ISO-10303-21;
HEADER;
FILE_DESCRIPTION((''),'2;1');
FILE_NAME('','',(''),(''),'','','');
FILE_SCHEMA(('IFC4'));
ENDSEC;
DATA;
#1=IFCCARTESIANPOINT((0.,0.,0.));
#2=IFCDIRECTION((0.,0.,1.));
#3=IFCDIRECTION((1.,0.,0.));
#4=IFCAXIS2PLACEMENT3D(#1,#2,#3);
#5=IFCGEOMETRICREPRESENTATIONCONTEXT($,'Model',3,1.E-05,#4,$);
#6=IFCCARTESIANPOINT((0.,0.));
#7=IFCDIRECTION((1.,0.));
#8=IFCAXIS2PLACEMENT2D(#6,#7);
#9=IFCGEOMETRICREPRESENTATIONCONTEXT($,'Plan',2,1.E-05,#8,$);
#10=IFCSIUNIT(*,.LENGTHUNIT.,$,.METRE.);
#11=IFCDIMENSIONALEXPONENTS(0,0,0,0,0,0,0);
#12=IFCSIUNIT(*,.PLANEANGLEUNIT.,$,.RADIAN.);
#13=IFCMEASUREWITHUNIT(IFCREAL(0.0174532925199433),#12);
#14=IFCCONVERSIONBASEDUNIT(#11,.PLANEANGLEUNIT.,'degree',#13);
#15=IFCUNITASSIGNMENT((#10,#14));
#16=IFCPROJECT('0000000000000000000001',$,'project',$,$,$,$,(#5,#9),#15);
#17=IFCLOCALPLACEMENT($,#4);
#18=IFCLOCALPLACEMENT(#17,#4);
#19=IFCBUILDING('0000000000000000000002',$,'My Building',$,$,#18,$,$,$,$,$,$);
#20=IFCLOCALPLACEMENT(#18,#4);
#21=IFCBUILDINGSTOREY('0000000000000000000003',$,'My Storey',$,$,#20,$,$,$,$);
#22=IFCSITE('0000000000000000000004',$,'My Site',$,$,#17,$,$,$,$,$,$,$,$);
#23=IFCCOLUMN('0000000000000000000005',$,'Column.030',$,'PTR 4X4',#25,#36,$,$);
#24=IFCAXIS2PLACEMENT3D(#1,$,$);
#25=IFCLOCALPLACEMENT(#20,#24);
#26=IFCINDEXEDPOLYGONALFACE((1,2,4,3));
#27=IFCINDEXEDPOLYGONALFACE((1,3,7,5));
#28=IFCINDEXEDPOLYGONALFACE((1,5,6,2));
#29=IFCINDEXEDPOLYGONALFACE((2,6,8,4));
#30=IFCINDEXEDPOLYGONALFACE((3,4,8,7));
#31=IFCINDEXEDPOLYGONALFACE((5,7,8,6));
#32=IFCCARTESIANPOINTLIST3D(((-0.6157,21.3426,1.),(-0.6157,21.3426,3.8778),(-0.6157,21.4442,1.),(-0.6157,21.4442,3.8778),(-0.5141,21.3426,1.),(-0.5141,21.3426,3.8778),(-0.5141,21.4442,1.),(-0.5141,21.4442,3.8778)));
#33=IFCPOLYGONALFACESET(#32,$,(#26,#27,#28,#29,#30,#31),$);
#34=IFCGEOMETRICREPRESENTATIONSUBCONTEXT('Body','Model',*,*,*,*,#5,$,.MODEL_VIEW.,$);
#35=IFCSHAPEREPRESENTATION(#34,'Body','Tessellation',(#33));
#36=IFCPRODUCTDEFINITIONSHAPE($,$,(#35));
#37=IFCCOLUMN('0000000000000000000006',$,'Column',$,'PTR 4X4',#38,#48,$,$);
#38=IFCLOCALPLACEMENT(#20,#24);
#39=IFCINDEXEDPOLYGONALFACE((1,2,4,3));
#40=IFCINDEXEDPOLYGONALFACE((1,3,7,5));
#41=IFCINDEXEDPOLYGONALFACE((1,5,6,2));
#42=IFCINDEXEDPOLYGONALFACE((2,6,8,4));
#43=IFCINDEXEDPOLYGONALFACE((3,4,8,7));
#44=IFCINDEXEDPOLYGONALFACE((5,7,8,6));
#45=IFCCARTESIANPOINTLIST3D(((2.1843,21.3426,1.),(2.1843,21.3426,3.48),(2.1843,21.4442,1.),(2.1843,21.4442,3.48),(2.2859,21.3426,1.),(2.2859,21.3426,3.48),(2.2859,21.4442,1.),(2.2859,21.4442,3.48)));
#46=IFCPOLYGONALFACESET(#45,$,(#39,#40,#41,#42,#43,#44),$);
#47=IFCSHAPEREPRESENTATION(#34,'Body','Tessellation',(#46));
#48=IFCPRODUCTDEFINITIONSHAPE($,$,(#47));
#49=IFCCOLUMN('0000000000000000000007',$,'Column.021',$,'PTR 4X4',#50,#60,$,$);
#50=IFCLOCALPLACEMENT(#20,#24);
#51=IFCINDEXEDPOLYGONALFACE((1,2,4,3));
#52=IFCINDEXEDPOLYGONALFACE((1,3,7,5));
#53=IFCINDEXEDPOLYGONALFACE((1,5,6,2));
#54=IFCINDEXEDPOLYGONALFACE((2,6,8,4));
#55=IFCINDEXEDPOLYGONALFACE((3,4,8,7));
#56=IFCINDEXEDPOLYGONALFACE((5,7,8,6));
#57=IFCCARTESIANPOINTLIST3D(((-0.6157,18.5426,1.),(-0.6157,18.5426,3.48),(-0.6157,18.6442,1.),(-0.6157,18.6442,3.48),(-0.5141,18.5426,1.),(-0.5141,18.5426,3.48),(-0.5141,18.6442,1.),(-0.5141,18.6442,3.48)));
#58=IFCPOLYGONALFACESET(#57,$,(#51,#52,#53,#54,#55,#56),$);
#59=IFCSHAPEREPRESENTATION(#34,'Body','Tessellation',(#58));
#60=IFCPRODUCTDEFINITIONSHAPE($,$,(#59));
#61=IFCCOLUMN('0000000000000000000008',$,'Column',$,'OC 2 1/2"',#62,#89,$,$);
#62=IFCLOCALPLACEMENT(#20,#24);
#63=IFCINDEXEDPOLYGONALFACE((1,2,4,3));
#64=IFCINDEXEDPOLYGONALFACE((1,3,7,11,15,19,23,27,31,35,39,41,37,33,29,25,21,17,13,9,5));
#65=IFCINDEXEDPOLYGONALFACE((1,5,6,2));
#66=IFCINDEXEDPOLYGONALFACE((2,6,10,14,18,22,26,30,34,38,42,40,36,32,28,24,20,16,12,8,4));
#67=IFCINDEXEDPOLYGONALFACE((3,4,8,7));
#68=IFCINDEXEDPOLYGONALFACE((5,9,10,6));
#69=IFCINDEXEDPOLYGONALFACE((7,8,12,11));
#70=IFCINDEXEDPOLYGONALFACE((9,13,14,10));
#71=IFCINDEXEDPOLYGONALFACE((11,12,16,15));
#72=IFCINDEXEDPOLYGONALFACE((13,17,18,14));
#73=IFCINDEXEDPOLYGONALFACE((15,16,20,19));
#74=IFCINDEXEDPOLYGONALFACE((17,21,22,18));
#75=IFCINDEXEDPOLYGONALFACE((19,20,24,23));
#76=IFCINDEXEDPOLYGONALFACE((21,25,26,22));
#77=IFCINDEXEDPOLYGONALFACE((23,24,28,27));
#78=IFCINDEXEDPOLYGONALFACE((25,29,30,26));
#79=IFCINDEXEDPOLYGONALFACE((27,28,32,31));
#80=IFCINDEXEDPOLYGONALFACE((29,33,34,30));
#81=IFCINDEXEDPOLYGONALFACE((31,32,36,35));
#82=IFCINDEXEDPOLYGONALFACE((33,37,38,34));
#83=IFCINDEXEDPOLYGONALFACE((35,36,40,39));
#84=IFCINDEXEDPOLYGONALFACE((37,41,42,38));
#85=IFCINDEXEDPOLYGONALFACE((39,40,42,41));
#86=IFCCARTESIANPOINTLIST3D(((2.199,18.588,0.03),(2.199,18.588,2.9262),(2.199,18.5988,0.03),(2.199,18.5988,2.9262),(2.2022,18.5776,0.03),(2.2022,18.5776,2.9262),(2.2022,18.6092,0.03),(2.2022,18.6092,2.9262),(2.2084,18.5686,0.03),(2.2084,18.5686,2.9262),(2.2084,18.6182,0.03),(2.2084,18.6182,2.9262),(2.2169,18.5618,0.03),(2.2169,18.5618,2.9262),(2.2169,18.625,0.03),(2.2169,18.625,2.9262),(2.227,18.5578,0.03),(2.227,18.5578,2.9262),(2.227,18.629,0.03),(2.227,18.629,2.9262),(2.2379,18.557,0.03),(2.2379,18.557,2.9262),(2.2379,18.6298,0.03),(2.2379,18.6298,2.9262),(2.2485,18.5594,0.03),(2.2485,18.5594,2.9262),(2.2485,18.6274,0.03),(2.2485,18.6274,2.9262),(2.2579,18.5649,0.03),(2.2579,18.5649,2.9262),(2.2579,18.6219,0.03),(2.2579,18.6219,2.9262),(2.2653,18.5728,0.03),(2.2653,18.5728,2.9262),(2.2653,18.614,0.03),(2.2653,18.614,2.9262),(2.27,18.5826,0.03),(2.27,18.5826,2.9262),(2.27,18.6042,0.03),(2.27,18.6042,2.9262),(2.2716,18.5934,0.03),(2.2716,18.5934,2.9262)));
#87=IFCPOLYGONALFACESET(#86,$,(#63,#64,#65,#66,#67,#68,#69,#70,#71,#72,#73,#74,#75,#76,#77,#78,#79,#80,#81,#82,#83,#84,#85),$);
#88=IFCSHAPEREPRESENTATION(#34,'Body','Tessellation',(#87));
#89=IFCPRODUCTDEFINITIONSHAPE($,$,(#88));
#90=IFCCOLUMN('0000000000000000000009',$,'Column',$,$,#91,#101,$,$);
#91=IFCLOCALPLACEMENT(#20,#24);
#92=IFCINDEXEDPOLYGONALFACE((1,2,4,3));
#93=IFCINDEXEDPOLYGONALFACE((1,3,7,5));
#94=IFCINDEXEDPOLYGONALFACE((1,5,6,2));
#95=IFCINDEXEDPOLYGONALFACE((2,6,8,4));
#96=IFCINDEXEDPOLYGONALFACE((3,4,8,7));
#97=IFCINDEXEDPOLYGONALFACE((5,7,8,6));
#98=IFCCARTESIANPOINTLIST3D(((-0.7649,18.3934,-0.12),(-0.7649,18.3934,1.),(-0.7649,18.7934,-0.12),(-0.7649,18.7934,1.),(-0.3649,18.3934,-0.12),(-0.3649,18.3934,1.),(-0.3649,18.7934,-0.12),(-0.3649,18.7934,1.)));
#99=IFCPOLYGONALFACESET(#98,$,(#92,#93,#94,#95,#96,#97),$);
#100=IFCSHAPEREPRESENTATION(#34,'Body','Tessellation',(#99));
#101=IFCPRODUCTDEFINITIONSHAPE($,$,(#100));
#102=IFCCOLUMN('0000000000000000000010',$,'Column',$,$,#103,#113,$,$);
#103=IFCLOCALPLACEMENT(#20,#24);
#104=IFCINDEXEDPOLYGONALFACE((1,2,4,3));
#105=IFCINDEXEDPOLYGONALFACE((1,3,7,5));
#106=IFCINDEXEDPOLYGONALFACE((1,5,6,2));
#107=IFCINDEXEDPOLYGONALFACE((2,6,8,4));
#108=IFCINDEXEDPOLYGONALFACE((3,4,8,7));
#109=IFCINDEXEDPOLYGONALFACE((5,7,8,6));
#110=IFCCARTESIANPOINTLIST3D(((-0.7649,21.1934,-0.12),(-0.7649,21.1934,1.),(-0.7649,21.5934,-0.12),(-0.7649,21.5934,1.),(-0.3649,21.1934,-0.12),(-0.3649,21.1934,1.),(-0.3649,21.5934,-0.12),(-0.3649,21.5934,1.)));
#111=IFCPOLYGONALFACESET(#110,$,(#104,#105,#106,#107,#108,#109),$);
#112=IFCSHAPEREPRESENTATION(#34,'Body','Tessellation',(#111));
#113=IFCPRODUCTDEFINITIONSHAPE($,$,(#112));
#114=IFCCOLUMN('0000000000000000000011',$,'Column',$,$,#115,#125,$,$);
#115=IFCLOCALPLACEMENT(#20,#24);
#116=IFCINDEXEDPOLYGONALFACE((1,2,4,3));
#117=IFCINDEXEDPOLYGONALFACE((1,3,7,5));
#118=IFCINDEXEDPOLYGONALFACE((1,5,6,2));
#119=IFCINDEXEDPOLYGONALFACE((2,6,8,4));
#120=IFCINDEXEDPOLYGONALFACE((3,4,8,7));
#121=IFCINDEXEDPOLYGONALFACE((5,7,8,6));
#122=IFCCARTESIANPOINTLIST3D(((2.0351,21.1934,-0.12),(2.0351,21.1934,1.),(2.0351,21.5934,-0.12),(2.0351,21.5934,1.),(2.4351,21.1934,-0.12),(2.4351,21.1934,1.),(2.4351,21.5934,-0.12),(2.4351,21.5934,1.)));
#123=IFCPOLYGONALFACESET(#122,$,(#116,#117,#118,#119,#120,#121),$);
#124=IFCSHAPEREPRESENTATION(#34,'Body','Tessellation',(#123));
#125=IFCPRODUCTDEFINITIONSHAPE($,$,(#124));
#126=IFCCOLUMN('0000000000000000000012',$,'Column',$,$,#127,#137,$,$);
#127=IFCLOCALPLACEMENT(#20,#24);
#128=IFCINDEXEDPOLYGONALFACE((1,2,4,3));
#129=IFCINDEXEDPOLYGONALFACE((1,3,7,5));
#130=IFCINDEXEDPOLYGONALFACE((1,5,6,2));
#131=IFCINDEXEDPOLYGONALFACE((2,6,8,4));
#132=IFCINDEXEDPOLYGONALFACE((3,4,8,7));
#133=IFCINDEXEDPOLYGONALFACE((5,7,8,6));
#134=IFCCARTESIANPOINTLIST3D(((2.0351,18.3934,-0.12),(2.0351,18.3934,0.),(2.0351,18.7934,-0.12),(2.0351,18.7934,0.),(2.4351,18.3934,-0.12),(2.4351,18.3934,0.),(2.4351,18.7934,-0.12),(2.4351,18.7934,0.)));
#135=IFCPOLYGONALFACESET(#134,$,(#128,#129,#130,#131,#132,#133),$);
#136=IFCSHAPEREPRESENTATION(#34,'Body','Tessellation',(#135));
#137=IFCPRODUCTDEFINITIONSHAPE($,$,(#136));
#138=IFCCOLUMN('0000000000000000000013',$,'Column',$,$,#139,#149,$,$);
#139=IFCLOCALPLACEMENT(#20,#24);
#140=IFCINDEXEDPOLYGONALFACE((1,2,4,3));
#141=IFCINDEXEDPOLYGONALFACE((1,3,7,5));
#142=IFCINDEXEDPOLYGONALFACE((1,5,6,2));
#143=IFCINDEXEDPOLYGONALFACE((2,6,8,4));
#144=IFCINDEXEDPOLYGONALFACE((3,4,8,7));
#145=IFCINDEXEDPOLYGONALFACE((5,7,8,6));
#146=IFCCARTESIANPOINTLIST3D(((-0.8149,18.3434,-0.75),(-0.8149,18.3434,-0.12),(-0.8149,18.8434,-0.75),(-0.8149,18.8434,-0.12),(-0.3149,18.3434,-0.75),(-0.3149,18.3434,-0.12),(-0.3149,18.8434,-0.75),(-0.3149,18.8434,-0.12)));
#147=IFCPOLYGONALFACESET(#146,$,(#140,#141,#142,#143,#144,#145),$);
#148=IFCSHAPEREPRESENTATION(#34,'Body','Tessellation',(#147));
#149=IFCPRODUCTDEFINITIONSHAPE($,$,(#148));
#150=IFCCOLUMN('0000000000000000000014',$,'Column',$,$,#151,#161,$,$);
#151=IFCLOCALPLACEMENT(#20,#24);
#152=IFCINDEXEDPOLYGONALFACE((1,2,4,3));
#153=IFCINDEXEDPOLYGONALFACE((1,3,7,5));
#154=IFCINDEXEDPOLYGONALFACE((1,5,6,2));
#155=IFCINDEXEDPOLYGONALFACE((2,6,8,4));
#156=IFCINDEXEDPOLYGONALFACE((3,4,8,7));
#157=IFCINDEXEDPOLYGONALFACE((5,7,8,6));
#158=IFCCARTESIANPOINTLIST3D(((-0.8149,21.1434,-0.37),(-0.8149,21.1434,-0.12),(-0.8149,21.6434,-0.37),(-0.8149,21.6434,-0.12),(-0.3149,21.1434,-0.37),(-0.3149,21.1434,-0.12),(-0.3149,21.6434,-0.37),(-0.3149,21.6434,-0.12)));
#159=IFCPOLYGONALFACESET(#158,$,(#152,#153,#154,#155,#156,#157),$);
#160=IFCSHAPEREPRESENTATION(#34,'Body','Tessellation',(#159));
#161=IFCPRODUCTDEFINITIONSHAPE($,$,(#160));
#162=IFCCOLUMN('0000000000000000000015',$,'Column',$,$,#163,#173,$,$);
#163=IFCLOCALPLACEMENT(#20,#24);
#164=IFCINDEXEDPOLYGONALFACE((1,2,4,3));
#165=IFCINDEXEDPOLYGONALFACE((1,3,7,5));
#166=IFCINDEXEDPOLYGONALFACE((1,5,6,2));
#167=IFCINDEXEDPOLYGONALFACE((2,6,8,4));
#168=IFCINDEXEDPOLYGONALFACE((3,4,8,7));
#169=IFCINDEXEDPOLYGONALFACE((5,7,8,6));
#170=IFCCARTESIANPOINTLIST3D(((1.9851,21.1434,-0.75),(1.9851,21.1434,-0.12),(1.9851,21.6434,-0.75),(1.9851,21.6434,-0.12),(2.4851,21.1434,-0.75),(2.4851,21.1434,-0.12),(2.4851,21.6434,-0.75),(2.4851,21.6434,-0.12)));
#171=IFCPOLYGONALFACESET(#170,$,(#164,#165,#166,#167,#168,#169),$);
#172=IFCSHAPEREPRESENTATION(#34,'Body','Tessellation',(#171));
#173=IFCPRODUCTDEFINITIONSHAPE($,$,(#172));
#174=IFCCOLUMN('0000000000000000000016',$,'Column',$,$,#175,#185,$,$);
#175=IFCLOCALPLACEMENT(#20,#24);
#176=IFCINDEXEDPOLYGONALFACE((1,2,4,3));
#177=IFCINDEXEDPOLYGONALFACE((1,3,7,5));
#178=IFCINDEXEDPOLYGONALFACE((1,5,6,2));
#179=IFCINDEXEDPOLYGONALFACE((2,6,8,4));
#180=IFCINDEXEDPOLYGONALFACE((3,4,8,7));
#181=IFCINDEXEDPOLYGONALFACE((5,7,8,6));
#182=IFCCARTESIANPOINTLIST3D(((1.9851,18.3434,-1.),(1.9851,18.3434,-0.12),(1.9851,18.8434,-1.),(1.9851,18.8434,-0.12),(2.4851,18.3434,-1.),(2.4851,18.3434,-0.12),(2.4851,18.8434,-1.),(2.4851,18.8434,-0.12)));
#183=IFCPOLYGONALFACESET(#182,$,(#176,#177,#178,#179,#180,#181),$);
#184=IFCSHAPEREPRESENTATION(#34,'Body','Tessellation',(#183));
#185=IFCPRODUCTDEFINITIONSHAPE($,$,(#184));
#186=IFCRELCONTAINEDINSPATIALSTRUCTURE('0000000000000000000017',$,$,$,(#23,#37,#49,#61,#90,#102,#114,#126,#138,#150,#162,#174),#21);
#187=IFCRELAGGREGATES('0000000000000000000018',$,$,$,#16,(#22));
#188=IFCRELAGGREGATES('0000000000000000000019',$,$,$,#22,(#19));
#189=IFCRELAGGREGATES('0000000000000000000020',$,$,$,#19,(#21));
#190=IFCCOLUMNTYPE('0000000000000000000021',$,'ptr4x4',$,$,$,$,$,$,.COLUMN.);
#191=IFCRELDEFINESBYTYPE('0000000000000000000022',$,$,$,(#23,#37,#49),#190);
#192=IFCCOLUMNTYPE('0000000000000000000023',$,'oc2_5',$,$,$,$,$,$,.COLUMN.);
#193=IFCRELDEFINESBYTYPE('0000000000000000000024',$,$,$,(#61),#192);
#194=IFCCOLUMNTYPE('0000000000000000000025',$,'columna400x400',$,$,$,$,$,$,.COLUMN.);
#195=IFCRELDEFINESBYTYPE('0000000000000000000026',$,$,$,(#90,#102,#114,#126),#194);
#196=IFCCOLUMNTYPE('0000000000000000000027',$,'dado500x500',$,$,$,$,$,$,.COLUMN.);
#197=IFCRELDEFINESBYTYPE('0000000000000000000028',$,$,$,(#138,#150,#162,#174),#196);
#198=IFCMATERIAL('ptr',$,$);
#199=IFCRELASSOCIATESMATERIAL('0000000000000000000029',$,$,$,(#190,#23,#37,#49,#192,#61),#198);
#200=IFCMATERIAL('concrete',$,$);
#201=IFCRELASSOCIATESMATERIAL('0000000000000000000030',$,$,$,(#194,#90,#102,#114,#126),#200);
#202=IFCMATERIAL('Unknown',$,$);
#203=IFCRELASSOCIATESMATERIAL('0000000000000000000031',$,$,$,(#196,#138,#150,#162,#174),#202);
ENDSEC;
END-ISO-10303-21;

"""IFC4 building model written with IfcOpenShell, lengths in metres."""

from ifc_helpers import new_model, entity, si_unit, converted_unit, frame, origin_with_axes, origin_2d_with_axis, place, context, subcontext, project, spatial, rectangle, circle, extrude, material, material_profile, profile_set, profile_usage, type_object, element, save


model = new_model("IFC4")

# Units and contexts
model_context = context("Model", 3, precision=1e-05, world=origin_with_axes())
plan_context = context("Plan", 2, precision=1e-05, world=origin_2d_with_axis())
body_context = subcontext(model_context, "Body", "Model", "MODEL_VIEW")
ifc_project = project(units=[si_unit("LENGTHUNIT", "METRE"), converted_unit("PLANEANGLEUNIT", "degree", entity("IfcReal", 0.0174532925199433), si_unit("PLANEANGLEUNIT", "RADIAN"), dimensions=[0, 0, 0, 0, 0, 0, 0])], contexts=[model_context, plan_context])

# Site, building, storey
site_placement = place(None, origin_with_axes())
site = spatial("IfcSite", under=ifc_project, at=site_placement, Name="My Site")
building_placement = place(site_placement, origin_with_axes())
building = spatial("IfcBuilding", under=site, at=building_placement, Name="My Building")
storey_placement = place(building_placement, origin_with_axes())
storey = spatial("IfcBuildingStorey", under=building, at=storey_placement, Name="My Storey")

# Columns
ifc_material_1 = material(Name="ptr")
ifc_material_profile_1 = material_profile(ifc_material_1, rectangle(XDim=0.1016, YDim=0.1016))
ifc_profile_set_1 = profile_set([ifc_material_profile_1])
ifc_profile_usage_1 = profile_usage(ifc_profile_set_1, cardinal=5)
column_type_1 = type_object("IfcColumnType", Name="ptr4x4", PredefinedType="COLUMN", material=ifc_profile_set_1)
column_1_placement = place(storey_placement, frame((-0.5649, 21.3934, 1.0), z_axis=(0.0, 0.0, 1.0), x_axis=(1.0, 0.0, 0.0)))
element("IfcColumn", 1, at=column_1_placement, inside=storey, type_object=column_type_1, material=ifc_profile_usage_1, Name="Column.030", ObjectType="PTR 4X4", context=body_context, shape_type="SweptSolid", body=[
    extrude(rectangle(XDim=0.1016, YDim=0.1016), origin_with_axes(), (0.0, 0.0, 1.0), 2.8778),
])
ifc_profile_usage_2 = profile_usage(ifc_profile_set_1, cardinal=5)
column_2_placement = place(storey_placement, frame((2.2351, 21.3934, 1.0), z_axis=(0.0, 0.0, 1.0), x_axis=(1.0, 0.0, 0.0)))
element("IfcColumn", 2, at=column_2_placement, inside=storey, type_object=column_type_1, material=ifc_profile_usage_2, Name="Column", ObjectType="PTR 4X4", context=body_context, shape_type="SweptSolid", body=[
    extrude(rectangle(XDim=0.1016, YDim=0.1016), origin_with_axes(), (0.0, 0.0, 1.0), 2.48),
])
ifc_profile_usage_3 = profile_usage(ifc_profile_set_1, cardinal=5)
column_3_placement = place(storey_placement, frame((-0.5649, 18.5934, 1.0), z_axis=(0.0, 0.0, 1.0), x_axis=(1.0, 0.0, 0.0)))
element("IfcColumn", 3, at=column_3_placement, inside=storey, type_object=column_type_1, material=ifc_profile_usage_3, Name="Column.021", ObjectType="PTR 4X4", context=body_context, shape_type="SweptSolid", body=[
    extrude(rectangle(XDim=0.1016, YDim=0.1016), origin_with_axes(), (0.0, 0.0, 1.0), 2.48),
])
ifc_material_profile_2 = material_profile(ifc_material_1, circle(Radius=0.0365))
ifc_profile_set_2 = profile_set([ifc_material_profile_2])
ifc_profile_usage_4 = profile_usage(ifc_profile_set_2)
column_type_2 = type_object("IfcColumnType", Name="oc2_5", PredefinedType="COLUMN", material=ifc_profile_set_2)
column_4_placement = place(storey_placement, frame((2.2351, 18.5934, 0.03), z_axis=(0.0, 0.0, 1.0), x_axis=(1.0, 0.0, 0.0)))
element("IfcColumn", 4, at=column_4_placement, inside=storey, type_object=column_type_2, material=ifc_profile_usage_4, Name="Column", ObjectType="OC 2 1/2\"", context=body_context, shape_type="SweptSolid", body=[
    extrude(circle(Radius=0.0365), origin_with_axes(), (0.0, 0.0, 1.0), 2.8962),
])
ifc_material_2 = material(Name="concrete")
ifc_material_profile_3 = material_profile(ifc_material_2, rectangle(XDim=0.4, YDim=0.4))
ifc_profile_set_3 = profile_set([ifc_material_profile_3], Name="concrete")
ifc_profile_usage_5 = profile_usage(ifc_profile_set_3)
column_type_3 = type_object("IfcColumnType", Name="columna400x400", PredefinedType="COLUMN", material=ifc_profile_set_3)
column_5_placement = place(storey_placement, frame((-0.5649, 18.5934, -0.12), z_axis=(0.0, 0.0, 1.0), x_axis=(1.0, 0.0, 0.0)))
element("IfcColumn", 5, at=column_5_placement, inside=storey, type_object=column_type_3, material=ifc_profile_usage_5, Name="Column", context=body_context, shape_type="SweptSolid", body=[
    extrude(rectangle(XDim=0.4, YDim=0.4), origin_with_axes(), (0.0, 0.0, 1.0), 1.12),
])
ifc_profile_usage_6 = profile_usage(ifc_profile_set_3)
column_6_placement = place(storey_placement, frame((-0.5649, 21.3934, -0.12), z_axis=(0.0, 0.0, 1.0), x_axis=(1.0, 0.0, 0.0)))
element("IfcColumn", 6, at=column_6_placement, inside=storey, type_object=column_type_3, material=ifc_profile_usage_6, Name="Column", context=body_context, shape_type="SweptSolid", body=[
    extrude(rectangle(XDim=0.4, YDim=0.4), origin_with_axes(), (0.0, 0.0, 1.0), 1.12),
])
ifc_profile_usage_7 = profile_usage(ifc_profile_set_3)
column_7_placement = place(storey_placement, frame((2.2351, 21.3934, -0.12), z_axis=(0.0, 0.0, 1.0), x_axis=(1.0, 0.0, 0.0)))
element("IfcColumn", 7, at=column_7_placement, inside=storey, type_object=column_type_3, material=ifc_profile_usage_7, Name="Column", context=body_context, shape_type="SweptSolid", body=[
    extrude(rectangle(XDim=0.4, YDim=0.4), origin_with_axes(), (0.0, 0.0, 1.0), 1.12),
])
ifc_profile_usage_8 = profile_usage(ifc_profile_set_3)
column_8_placement = place(storey_placement, frame((2.2351, 18.5934, -0.12), z_axis=(0.0, 0.0, 1.0), x_axis=(1.0, 0.0, 0.0)))
element("IfcColumn", 8, at=column_8_placement, inside=storey, type_object=column_type_3, material=ifc_profile_usage_8, Name="Column", context=body_context, shape_type="SweptSolid", body=[
    extrude(rectangle(XDim=0.4, YDim=0.4), origin_with_axes(), (0.0, 0.0, 1.0), 0.12),
])
ifc_material_3 = material(Name="Unknown")
ifc_material_profile_4 = material_profile(ifc_material_3, rectangle(XDim=0.5, YDim=0.5))
ifc_profile_set_4 = profile_set([ifc_material_profile_4], Name="concrete")
ifc_profile_usage_9 = profile_usage(ifc_profile_set_4)
column_type_4 = type_object("IfcColumnType", Name="dado500x500", PredefinedType="COLUMN", material=ifc_profile_set_4)
column_9_placement = place(storey_placement, frame((-0.5649, 18.5934, -0.75), z_axis=(0.0, 0.0, 1.0), x_axis=(1.0, 0.0, 0.0)))
element("IfcColumn", 9, at=column_9_placement, inside=storey, type_object=column_type_4, material=ifc_profile_usage_9, Name="Column", context=body_context, shape_type="SweptSolid", body=[
    extrude(rectangle(XDim=0.5, YDim=0.5), origin_with_axes(), (0.0, 0.0, 1.0), 0.63),
])
ifc_profile_usage_10 = profile_usage(ifc_profile_set_4)
column_10_placement = place(storey_placement, frame((-0.5649, 21.3934, -0.37), z_axis=(0.0, 0.0, 1.0), x_axis=(1.0, 0.0, 0.0)))
element("IfcColumn", 10, at=column_10_placement, inside=storey, type_object=column_type_4, material=ifc_profile_usage_10, Name="Column", context=body_context, shape_type="SweptSolid", body=[
    extrude(rectangle(XDim=0.5, YDim=0.5), origin_with_axes(), (0.0, 0.0, 1.0), 0.25),
])
ifc_profile_usage_11 = profile_usage(ifc_profile_set_4)
column_11_placement = place(storey_placement, frame((2.2351, 21.3934, -0.75), z_axis=(0.0, 0.0, 1.0), x_axis=(1.0, 0.0, 0.0)))
element("IfcColumn", 11, at=column_11_placement, inside=storey, type_object=column_type_4, material=ifc_profile_usage_11, Name="Column", context=body_context, shape_type="SweptSolid", body=[
    extrude(rectangle(XDim=0.5, YDim=0.5), origin_with_axes(), (0.0, 0.0, 1.0), 0.63),
])
ifc_profile_usage_12 = profile_usage(ifc_profile_set_4)
column_12_placement = place(storey_placement, frame((2.2351, 18.5934, -1.0), z_axis=(0.0, 0.0, 1.0), x_axis=(1.0, 0.0, 0.0)))
element("IfcColumn", 12, at=column_12_placement, inside=storey, type_object=column_type_4, material=ifc_profile_usage_12, Name="Column", context=body_context, shape_type="SweptSolid", body=[
    extrude(rectangle(XDim=0.5, YDim=0.5), origin_with_axes(), (0.0, 0.0, 1.0), 0.88),
])

save(model, "model.ifc")
